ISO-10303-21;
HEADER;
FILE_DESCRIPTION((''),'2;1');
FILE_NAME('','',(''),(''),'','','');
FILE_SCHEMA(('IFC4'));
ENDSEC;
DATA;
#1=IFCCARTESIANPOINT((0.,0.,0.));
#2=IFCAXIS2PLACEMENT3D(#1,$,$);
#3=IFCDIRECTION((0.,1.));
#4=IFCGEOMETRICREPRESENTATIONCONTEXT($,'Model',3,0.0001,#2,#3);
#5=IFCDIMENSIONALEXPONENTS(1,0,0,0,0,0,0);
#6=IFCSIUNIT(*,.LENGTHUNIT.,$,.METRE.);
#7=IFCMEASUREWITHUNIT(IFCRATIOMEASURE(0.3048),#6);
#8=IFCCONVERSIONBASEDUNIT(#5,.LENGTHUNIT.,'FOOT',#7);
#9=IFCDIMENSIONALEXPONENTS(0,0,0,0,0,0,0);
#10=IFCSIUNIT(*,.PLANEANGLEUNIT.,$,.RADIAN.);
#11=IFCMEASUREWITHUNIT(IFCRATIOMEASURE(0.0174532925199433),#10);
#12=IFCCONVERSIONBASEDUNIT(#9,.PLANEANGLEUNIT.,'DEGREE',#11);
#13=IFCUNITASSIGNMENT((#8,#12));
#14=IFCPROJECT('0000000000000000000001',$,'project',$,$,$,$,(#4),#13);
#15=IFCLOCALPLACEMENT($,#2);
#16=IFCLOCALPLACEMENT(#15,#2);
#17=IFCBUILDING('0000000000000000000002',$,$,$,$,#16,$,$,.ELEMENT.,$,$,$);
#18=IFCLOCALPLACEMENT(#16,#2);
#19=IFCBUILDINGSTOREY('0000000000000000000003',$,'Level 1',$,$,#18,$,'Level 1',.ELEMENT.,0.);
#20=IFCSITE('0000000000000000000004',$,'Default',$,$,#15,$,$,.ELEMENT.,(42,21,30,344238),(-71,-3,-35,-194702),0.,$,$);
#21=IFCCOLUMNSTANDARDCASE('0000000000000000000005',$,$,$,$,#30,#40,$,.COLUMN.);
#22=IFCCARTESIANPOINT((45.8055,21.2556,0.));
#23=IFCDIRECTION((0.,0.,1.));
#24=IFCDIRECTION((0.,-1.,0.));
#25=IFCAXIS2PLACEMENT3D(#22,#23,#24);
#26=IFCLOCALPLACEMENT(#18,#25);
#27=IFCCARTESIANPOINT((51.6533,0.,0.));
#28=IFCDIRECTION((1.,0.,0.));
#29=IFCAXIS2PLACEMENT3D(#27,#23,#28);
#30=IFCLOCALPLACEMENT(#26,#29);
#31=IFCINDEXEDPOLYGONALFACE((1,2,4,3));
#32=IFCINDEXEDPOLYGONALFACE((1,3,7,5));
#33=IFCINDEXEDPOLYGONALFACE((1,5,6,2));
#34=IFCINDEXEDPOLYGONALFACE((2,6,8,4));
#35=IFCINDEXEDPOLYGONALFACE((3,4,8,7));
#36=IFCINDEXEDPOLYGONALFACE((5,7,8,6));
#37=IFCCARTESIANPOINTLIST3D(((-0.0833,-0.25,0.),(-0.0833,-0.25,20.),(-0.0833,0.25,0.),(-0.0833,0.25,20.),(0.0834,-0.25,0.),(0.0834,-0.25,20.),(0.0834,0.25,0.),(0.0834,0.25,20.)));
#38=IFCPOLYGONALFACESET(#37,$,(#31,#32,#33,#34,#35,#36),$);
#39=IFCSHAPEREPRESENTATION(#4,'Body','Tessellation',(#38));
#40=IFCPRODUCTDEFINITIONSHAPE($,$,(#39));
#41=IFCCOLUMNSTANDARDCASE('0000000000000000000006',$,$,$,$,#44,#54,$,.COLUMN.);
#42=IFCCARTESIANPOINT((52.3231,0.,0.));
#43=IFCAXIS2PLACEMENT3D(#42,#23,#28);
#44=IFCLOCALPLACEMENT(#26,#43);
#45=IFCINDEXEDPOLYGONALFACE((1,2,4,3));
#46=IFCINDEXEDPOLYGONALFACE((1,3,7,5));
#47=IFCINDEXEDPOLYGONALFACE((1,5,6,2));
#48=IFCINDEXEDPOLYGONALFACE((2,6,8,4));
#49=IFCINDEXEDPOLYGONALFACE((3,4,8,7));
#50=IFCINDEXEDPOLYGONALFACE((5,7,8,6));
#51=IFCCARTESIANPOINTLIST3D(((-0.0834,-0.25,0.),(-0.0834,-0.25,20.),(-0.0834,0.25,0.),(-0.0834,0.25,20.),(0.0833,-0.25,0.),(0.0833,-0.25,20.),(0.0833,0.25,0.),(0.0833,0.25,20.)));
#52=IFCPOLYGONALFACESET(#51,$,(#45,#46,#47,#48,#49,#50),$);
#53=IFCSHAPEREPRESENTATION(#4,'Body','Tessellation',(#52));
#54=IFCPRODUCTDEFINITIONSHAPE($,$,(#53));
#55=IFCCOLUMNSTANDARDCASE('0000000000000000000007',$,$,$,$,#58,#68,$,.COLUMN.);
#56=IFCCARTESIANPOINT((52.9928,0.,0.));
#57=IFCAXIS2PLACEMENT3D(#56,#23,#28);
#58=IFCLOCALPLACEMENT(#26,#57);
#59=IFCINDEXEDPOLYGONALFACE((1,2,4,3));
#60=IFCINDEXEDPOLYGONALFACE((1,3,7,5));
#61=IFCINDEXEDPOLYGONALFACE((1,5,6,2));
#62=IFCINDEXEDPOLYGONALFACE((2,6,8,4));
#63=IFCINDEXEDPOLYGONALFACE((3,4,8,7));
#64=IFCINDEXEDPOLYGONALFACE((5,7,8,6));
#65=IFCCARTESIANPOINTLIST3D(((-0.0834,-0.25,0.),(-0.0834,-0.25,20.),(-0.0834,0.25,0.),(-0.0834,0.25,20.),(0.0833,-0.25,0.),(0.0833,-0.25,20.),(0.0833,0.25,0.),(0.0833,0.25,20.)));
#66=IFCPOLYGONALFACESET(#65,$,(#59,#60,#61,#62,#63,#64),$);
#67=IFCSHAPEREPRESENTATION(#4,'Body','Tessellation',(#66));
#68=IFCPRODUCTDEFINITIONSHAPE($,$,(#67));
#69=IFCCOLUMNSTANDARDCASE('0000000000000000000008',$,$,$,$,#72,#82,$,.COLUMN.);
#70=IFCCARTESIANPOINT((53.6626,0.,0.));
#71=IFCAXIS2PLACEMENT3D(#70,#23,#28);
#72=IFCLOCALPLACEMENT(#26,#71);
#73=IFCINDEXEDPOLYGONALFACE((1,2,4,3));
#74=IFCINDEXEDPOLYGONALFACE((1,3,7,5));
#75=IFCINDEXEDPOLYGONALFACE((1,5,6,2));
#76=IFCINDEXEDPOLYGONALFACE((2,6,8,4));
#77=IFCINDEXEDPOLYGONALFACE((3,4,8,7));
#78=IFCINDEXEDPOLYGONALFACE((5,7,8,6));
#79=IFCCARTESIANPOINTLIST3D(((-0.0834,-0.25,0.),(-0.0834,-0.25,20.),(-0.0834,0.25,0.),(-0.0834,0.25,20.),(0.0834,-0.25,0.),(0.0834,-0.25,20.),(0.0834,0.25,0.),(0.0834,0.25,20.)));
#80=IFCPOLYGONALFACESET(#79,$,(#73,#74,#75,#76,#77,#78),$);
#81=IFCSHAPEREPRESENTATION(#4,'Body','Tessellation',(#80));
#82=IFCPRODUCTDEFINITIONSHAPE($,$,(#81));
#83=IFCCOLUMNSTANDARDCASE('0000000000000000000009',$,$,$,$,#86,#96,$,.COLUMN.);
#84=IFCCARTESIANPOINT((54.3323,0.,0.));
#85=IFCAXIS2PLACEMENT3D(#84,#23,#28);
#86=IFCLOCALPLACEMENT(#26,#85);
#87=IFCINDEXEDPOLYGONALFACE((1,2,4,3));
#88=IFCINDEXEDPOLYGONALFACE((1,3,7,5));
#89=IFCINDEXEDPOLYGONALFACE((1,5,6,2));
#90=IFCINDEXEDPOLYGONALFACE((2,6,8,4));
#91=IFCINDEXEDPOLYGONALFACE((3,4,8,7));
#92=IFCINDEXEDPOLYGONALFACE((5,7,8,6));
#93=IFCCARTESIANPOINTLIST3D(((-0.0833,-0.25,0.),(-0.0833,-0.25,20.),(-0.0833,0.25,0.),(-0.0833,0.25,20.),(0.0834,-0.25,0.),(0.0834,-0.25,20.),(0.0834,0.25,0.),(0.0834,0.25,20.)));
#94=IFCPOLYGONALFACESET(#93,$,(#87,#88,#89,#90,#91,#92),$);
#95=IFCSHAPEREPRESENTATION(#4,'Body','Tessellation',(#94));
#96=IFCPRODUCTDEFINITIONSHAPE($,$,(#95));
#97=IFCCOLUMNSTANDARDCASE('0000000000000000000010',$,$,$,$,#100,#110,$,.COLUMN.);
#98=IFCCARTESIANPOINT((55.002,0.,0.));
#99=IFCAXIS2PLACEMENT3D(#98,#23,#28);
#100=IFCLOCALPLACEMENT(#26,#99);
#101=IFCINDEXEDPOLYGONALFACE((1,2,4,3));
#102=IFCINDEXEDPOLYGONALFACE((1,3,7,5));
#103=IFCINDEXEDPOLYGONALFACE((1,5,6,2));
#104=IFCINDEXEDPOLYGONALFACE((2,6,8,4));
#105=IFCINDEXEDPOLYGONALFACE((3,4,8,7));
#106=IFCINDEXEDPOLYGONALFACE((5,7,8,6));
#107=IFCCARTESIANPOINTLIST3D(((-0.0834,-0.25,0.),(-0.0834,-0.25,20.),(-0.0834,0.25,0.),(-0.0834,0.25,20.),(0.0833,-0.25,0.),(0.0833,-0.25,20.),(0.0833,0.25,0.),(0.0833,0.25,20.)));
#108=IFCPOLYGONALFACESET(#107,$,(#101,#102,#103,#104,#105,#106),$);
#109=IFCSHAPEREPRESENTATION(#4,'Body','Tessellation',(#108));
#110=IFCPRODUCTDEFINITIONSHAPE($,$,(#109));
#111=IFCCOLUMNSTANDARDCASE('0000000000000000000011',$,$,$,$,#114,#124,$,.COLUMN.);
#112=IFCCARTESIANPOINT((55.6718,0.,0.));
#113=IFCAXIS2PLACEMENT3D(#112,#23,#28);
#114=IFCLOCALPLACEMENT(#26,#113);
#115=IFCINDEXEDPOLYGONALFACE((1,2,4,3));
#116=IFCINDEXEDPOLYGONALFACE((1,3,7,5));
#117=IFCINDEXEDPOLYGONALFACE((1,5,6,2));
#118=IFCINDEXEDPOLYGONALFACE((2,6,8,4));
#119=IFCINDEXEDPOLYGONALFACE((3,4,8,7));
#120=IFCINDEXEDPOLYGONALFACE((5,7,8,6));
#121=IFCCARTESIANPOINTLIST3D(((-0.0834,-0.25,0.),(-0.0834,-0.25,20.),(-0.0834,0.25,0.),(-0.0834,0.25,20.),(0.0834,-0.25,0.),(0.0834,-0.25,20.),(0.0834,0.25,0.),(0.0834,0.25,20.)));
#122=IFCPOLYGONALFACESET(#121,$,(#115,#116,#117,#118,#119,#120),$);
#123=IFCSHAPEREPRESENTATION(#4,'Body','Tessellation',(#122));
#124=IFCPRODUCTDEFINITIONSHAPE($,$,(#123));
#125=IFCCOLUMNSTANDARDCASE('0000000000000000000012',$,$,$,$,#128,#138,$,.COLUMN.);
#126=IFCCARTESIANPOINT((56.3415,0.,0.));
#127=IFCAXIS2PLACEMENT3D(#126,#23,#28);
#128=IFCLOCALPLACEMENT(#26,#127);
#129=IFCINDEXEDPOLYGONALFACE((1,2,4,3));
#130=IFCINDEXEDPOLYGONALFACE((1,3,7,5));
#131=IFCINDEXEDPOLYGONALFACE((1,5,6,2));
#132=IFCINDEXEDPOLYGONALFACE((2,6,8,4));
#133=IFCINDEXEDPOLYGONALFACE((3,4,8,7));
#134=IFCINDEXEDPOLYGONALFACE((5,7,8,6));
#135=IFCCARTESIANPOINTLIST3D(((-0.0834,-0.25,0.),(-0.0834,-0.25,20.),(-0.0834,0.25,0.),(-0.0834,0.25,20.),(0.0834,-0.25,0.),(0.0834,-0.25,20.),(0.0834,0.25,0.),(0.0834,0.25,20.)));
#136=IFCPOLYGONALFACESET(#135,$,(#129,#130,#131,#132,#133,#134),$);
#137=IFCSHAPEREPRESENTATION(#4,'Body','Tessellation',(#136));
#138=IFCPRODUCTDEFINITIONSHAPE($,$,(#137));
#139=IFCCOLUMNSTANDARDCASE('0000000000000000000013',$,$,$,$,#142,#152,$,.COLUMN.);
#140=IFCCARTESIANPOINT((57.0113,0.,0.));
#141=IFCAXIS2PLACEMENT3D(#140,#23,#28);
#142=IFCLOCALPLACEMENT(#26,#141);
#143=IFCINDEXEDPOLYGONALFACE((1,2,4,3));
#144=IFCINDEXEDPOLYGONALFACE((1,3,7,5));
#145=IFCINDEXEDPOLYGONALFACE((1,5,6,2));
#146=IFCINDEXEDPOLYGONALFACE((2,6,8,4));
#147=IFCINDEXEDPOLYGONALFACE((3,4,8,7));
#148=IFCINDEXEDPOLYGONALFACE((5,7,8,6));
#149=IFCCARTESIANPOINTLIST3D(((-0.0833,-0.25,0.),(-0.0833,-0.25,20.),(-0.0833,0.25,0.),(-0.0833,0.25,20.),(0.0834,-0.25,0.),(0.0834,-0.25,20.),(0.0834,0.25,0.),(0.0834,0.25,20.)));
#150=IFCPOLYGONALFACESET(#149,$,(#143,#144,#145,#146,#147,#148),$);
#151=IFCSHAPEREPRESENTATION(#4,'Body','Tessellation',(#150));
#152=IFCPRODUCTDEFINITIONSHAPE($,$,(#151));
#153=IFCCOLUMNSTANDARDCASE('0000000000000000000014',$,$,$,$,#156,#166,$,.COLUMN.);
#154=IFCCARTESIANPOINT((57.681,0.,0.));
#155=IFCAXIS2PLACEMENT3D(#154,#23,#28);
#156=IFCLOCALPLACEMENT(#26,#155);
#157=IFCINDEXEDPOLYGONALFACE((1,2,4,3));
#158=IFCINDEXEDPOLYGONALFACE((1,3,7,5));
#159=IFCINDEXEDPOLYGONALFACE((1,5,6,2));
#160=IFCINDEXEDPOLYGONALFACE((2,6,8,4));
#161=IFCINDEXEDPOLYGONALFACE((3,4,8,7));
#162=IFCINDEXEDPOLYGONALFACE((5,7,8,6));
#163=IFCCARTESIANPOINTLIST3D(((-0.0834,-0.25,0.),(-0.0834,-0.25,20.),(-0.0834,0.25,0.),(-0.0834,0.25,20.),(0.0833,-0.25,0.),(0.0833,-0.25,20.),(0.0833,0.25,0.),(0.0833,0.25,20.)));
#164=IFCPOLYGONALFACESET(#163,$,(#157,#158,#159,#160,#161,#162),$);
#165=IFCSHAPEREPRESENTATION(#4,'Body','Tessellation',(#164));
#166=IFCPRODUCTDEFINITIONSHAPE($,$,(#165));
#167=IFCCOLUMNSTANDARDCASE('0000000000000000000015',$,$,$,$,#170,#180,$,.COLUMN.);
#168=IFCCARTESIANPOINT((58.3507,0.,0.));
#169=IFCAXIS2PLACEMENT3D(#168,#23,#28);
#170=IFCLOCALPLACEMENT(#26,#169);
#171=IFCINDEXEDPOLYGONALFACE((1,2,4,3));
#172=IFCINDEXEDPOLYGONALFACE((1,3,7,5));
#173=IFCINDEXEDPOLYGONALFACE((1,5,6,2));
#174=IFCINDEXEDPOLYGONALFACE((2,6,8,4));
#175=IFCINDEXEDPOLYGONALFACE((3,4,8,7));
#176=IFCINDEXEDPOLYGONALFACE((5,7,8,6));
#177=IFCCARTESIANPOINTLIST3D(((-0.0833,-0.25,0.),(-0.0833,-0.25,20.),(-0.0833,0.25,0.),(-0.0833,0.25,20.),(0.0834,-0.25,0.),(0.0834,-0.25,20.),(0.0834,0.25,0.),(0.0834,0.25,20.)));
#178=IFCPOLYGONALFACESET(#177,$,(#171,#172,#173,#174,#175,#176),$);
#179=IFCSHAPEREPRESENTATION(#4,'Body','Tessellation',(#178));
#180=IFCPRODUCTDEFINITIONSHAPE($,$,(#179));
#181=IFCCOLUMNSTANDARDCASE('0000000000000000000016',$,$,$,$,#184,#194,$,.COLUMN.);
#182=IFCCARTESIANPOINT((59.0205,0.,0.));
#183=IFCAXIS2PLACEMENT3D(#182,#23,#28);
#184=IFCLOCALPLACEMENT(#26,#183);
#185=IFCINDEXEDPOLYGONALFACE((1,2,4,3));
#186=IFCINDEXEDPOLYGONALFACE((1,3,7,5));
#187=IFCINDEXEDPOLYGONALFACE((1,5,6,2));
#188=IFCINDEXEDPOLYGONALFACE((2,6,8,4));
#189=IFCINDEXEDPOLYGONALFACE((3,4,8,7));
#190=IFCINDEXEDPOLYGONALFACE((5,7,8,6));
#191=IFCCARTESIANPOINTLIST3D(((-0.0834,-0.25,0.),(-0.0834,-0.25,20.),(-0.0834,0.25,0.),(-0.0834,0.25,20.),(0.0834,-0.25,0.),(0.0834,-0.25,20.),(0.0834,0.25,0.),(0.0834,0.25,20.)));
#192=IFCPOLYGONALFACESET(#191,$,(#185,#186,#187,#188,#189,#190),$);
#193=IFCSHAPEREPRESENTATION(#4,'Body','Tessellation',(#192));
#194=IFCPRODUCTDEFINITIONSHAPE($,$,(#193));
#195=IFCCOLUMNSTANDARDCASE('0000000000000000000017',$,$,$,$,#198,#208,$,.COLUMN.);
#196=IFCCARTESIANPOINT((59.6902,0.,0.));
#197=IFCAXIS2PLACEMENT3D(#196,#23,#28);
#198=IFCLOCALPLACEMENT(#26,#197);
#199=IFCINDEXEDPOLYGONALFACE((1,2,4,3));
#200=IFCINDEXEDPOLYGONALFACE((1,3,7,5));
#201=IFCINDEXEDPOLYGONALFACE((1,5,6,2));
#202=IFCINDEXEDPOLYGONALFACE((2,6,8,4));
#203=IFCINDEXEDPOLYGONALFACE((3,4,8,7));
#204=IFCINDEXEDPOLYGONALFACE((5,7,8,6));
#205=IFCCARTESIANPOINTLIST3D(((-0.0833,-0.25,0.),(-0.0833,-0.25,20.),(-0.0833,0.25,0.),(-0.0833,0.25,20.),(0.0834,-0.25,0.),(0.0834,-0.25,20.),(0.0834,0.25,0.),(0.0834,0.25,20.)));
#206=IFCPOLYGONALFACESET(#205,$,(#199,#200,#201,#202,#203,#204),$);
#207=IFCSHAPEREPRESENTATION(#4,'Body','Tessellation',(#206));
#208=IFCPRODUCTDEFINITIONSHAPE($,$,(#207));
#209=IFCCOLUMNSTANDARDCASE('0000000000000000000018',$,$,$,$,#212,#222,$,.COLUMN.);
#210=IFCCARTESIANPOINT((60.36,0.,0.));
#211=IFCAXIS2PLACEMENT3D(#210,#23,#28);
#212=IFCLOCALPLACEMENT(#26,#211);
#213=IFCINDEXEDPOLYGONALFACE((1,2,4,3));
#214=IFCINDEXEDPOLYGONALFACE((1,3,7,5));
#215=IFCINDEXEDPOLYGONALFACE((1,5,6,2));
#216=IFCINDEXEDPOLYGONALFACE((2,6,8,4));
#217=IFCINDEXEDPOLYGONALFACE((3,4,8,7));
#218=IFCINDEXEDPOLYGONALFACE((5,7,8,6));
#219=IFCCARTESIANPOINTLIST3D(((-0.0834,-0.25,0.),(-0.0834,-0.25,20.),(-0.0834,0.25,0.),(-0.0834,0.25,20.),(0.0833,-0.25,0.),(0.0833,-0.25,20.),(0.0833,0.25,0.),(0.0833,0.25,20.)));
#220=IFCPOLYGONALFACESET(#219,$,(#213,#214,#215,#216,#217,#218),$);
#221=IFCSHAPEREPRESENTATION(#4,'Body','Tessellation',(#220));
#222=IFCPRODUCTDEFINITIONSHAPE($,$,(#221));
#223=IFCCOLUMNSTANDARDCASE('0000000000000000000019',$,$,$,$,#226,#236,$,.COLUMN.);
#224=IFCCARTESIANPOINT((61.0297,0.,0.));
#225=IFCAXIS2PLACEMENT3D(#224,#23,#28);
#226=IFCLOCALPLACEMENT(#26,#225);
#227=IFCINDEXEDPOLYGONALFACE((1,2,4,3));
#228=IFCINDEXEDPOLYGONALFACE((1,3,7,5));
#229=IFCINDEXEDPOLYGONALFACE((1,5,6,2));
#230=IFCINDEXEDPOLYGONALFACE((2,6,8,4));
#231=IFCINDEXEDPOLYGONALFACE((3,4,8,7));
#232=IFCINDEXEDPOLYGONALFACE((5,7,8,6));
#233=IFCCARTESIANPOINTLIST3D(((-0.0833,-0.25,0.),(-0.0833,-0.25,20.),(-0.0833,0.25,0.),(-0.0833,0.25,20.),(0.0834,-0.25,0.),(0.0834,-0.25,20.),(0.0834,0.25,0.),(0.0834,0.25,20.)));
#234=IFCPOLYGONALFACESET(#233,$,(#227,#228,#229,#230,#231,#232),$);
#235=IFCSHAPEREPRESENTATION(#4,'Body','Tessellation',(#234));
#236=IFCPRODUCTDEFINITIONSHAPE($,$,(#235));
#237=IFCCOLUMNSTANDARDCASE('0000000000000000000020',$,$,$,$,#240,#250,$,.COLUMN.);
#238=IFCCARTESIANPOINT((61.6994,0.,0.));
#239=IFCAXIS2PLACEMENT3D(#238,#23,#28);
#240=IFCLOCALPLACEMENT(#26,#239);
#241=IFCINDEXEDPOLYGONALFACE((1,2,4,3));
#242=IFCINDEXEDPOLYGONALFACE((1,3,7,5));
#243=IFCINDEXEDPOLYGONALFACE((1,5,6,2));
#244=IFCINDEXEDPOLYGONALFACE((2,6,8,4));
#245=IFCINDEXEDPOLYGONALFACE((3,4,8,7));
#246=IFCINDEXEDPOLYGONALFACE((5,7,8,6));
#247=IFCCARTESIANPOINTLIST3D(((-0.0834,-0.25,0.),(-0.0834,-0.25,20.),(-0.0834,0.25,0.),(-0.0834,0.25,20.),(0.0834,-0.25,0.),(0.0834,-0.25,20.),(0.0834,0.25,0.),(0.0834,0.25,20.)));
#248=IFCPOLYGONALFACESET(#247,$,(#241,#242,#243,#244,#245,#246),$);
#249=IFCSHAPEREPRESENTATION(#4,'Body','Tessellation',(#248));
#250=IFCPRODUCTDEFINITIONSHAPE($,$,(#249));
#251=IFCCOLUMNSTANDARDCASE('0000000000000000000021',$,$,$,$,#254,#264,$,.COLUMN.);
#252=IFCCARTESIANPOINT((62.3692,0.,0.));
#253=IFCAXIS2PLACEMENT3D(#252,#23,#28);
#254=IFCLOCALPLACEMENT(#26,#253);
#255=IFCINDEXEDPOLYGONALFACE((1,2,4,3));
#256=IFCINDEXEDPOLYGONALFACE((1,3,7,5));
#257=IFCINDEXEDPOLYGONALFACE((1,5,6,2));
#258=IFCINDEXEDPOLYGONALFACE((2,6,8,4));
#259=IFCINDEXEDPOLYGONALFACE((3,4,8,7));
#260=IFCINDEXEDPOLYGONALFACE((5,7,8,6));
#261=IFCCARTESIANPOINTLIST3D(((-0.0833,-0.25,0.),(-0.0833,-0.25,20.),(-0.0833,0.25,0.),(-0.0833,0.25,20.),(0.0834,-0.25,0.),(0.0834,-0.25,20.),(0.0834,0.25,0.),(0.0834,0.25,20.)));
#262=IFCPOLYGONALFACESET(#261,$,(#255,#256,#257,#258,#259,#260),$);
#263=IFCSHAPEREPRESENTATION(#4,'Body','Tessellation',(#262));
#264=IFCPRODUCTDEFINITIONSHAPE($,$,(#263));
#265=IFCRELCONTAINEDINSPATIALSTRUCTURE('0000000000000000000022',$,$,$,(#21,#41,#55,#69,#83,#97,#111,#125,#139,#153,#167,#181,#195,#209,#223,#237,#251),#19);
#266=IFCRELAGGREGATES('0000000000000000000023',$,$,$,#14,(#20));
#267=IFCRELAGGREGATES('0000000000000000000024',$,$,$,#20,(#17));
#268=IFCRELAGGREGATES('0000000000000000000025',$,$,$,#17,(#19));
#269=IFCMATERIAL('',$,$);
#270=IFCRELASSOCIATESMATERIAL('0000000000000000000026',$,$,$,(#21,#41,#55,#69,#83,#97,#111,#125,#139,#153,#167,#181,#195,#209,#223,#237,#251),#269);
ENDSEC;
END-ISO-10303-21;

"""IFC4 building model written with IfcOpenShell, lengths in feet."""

from ifc_helpers import new_model, entity, si_unit, converted_unit, direction, frame, origin, place, context, project, spatial, rectangle, extrude, material, element, save


model = new_model("IFC4")

# Units and contexts
model_context = context("Model", 3, precision=0.0001, world=origin(), true_north=direction((0.0, 1.0)))
ifc_project = project(units=[converted_unit("LENGTHUNIT", "FOOT", entity("IfcRatioMeasure", 0.3048), si_unit("LENGTHUNIT", "METRE"), dimensions=[1, 0, 0, 0, 0, 0, 0]), converted_unit("PLANEANGLEUNIT", "DEGREE", entity("IfcRatioMeasure", 0.0174532925199433), si_unit("PLANEANGLEUNIT", "RADIAN"), dimensions=[0, 0, 0, 0, 0, 0, 0])], contexts=[model_context])

# Site, building, storey
site_placement = place(None, origin())
site = spatial("IfcSite", under=ifc_project, at=site_placement, Name="Default", CompositionType="ELEMENT", RefLatitude=(42, 21, 30, 344238), RefLongitude=(-71, -3, -35, -194702), RefElevation=0.0)
building_placement = place(site_placement, origin())
building = spatial("IfcBuilding", under=site, at=building_placement, CompositionType="ELEMENT")
storey_placement = place(building_placement, origin())
storey = spatial("IfcBuildingStorey", under=building, at=storey_placement, Name="Level 1", LongName="Level 1", CompositionType="ELEMENT", Elevation=0.0)

# Columns
ifc_material_1 = material(Name="")
placement = place(storey_placement, frame((45.8055, 21.2556, 0.0), z_axis=(0.0, 0.0, 1.0), x_axis=(0.0, -1.0, 0.0)))
for number, where, z_axis, x_axis in (
    (1, (51.6533, 0.0, 0.0), (0.0, 0.0, 1.0), (1.0, 0.0, 0.0)),
    (2, (52.3231, 0.0, 0.0), (0.0, 0.0, 1.0), (1.0, 0.0, 0.0)),
    (3, (52.9928, 0.0, 0.0), (0.0, 0.0, 1.0), (1.0, 0.0, 0.0)),
    (4, (53.6626, 0.0, 0.0), (0.0, 0.0, 1.0), (1.0, 0.0, 0.0)),
    (5, (54.3323, 0.0, 0.0), (0.0, 0.0, 1.0), (1.0, 0.0, 0.0)),
    (6, (55.002, 0.0, 0.0), (0.0, 0.0, 1.0), (1.0, 0.0, 0.0)),
    (7, (55.6718, 0.0, 0.0), (0.0, 0.0, 1.0), (1.0, 0.0, 0.0)),
    (8, (56.3415, 0.0, 0.0), (0.0, 0.0, 1.0), (1.0, 0.0, 0.0)),
    (9, (57.0113, 0.0, 0.0), (0.0, 0.0, 1.0), (1.0, 0.0, 0.0)),
    (10, (57.681, 0.0, 0.0), (0.0, 0.0, 1.0), (1.0, 0.0, 0.0)),
    (11, (58.3507, 0.0, 0.0), (0.0, 0.0, 1.0), (1.0, 0.0, 0.0)),
    (12, (59.0205, 0.0, 0.0), (0.0, 0.0, 1.0), (1.0, 0.0, 0.0)),
    (13, (59.6902, 0.0, 0.0), (0.0, 0.0, 1.0), (1.0, 0.0, 0.0)),
    (14, (60.36, 0.0, 0.0), (0.0, 0.0, 1.0), (1.0, 0.0, 0.0)),
    (15, (61.0297, 0.0, 0.0), (0.0, 0.0, 1.0), (1.0, 0.0, 0.0)),
    (16, (61.6994, 0.0, 0.0), (0.0, 0.0, 1.0), (1.0, 0.0, 0.0)),
    (17, (62.3692, 0.0, 0.0), (0.0, 0.0, 1.0), (1.0, 0.0, 0.0)),
):
    element("IfcColumnStandardCase", number, at=place(placement, frame(where, z_axis=z_axis, x_axis=x_axis)), inside=storey, material=ifc_material_1, PredefinedType="COLUMN", context=model_context, shape_type="SweptSolid", body=[
        extrude(rectangle(XDim=0.1667, YDim=0.5), origin(), (0.0, 0.0, 1.0), 20.0),
    ])

save(model, "model.ifc")
